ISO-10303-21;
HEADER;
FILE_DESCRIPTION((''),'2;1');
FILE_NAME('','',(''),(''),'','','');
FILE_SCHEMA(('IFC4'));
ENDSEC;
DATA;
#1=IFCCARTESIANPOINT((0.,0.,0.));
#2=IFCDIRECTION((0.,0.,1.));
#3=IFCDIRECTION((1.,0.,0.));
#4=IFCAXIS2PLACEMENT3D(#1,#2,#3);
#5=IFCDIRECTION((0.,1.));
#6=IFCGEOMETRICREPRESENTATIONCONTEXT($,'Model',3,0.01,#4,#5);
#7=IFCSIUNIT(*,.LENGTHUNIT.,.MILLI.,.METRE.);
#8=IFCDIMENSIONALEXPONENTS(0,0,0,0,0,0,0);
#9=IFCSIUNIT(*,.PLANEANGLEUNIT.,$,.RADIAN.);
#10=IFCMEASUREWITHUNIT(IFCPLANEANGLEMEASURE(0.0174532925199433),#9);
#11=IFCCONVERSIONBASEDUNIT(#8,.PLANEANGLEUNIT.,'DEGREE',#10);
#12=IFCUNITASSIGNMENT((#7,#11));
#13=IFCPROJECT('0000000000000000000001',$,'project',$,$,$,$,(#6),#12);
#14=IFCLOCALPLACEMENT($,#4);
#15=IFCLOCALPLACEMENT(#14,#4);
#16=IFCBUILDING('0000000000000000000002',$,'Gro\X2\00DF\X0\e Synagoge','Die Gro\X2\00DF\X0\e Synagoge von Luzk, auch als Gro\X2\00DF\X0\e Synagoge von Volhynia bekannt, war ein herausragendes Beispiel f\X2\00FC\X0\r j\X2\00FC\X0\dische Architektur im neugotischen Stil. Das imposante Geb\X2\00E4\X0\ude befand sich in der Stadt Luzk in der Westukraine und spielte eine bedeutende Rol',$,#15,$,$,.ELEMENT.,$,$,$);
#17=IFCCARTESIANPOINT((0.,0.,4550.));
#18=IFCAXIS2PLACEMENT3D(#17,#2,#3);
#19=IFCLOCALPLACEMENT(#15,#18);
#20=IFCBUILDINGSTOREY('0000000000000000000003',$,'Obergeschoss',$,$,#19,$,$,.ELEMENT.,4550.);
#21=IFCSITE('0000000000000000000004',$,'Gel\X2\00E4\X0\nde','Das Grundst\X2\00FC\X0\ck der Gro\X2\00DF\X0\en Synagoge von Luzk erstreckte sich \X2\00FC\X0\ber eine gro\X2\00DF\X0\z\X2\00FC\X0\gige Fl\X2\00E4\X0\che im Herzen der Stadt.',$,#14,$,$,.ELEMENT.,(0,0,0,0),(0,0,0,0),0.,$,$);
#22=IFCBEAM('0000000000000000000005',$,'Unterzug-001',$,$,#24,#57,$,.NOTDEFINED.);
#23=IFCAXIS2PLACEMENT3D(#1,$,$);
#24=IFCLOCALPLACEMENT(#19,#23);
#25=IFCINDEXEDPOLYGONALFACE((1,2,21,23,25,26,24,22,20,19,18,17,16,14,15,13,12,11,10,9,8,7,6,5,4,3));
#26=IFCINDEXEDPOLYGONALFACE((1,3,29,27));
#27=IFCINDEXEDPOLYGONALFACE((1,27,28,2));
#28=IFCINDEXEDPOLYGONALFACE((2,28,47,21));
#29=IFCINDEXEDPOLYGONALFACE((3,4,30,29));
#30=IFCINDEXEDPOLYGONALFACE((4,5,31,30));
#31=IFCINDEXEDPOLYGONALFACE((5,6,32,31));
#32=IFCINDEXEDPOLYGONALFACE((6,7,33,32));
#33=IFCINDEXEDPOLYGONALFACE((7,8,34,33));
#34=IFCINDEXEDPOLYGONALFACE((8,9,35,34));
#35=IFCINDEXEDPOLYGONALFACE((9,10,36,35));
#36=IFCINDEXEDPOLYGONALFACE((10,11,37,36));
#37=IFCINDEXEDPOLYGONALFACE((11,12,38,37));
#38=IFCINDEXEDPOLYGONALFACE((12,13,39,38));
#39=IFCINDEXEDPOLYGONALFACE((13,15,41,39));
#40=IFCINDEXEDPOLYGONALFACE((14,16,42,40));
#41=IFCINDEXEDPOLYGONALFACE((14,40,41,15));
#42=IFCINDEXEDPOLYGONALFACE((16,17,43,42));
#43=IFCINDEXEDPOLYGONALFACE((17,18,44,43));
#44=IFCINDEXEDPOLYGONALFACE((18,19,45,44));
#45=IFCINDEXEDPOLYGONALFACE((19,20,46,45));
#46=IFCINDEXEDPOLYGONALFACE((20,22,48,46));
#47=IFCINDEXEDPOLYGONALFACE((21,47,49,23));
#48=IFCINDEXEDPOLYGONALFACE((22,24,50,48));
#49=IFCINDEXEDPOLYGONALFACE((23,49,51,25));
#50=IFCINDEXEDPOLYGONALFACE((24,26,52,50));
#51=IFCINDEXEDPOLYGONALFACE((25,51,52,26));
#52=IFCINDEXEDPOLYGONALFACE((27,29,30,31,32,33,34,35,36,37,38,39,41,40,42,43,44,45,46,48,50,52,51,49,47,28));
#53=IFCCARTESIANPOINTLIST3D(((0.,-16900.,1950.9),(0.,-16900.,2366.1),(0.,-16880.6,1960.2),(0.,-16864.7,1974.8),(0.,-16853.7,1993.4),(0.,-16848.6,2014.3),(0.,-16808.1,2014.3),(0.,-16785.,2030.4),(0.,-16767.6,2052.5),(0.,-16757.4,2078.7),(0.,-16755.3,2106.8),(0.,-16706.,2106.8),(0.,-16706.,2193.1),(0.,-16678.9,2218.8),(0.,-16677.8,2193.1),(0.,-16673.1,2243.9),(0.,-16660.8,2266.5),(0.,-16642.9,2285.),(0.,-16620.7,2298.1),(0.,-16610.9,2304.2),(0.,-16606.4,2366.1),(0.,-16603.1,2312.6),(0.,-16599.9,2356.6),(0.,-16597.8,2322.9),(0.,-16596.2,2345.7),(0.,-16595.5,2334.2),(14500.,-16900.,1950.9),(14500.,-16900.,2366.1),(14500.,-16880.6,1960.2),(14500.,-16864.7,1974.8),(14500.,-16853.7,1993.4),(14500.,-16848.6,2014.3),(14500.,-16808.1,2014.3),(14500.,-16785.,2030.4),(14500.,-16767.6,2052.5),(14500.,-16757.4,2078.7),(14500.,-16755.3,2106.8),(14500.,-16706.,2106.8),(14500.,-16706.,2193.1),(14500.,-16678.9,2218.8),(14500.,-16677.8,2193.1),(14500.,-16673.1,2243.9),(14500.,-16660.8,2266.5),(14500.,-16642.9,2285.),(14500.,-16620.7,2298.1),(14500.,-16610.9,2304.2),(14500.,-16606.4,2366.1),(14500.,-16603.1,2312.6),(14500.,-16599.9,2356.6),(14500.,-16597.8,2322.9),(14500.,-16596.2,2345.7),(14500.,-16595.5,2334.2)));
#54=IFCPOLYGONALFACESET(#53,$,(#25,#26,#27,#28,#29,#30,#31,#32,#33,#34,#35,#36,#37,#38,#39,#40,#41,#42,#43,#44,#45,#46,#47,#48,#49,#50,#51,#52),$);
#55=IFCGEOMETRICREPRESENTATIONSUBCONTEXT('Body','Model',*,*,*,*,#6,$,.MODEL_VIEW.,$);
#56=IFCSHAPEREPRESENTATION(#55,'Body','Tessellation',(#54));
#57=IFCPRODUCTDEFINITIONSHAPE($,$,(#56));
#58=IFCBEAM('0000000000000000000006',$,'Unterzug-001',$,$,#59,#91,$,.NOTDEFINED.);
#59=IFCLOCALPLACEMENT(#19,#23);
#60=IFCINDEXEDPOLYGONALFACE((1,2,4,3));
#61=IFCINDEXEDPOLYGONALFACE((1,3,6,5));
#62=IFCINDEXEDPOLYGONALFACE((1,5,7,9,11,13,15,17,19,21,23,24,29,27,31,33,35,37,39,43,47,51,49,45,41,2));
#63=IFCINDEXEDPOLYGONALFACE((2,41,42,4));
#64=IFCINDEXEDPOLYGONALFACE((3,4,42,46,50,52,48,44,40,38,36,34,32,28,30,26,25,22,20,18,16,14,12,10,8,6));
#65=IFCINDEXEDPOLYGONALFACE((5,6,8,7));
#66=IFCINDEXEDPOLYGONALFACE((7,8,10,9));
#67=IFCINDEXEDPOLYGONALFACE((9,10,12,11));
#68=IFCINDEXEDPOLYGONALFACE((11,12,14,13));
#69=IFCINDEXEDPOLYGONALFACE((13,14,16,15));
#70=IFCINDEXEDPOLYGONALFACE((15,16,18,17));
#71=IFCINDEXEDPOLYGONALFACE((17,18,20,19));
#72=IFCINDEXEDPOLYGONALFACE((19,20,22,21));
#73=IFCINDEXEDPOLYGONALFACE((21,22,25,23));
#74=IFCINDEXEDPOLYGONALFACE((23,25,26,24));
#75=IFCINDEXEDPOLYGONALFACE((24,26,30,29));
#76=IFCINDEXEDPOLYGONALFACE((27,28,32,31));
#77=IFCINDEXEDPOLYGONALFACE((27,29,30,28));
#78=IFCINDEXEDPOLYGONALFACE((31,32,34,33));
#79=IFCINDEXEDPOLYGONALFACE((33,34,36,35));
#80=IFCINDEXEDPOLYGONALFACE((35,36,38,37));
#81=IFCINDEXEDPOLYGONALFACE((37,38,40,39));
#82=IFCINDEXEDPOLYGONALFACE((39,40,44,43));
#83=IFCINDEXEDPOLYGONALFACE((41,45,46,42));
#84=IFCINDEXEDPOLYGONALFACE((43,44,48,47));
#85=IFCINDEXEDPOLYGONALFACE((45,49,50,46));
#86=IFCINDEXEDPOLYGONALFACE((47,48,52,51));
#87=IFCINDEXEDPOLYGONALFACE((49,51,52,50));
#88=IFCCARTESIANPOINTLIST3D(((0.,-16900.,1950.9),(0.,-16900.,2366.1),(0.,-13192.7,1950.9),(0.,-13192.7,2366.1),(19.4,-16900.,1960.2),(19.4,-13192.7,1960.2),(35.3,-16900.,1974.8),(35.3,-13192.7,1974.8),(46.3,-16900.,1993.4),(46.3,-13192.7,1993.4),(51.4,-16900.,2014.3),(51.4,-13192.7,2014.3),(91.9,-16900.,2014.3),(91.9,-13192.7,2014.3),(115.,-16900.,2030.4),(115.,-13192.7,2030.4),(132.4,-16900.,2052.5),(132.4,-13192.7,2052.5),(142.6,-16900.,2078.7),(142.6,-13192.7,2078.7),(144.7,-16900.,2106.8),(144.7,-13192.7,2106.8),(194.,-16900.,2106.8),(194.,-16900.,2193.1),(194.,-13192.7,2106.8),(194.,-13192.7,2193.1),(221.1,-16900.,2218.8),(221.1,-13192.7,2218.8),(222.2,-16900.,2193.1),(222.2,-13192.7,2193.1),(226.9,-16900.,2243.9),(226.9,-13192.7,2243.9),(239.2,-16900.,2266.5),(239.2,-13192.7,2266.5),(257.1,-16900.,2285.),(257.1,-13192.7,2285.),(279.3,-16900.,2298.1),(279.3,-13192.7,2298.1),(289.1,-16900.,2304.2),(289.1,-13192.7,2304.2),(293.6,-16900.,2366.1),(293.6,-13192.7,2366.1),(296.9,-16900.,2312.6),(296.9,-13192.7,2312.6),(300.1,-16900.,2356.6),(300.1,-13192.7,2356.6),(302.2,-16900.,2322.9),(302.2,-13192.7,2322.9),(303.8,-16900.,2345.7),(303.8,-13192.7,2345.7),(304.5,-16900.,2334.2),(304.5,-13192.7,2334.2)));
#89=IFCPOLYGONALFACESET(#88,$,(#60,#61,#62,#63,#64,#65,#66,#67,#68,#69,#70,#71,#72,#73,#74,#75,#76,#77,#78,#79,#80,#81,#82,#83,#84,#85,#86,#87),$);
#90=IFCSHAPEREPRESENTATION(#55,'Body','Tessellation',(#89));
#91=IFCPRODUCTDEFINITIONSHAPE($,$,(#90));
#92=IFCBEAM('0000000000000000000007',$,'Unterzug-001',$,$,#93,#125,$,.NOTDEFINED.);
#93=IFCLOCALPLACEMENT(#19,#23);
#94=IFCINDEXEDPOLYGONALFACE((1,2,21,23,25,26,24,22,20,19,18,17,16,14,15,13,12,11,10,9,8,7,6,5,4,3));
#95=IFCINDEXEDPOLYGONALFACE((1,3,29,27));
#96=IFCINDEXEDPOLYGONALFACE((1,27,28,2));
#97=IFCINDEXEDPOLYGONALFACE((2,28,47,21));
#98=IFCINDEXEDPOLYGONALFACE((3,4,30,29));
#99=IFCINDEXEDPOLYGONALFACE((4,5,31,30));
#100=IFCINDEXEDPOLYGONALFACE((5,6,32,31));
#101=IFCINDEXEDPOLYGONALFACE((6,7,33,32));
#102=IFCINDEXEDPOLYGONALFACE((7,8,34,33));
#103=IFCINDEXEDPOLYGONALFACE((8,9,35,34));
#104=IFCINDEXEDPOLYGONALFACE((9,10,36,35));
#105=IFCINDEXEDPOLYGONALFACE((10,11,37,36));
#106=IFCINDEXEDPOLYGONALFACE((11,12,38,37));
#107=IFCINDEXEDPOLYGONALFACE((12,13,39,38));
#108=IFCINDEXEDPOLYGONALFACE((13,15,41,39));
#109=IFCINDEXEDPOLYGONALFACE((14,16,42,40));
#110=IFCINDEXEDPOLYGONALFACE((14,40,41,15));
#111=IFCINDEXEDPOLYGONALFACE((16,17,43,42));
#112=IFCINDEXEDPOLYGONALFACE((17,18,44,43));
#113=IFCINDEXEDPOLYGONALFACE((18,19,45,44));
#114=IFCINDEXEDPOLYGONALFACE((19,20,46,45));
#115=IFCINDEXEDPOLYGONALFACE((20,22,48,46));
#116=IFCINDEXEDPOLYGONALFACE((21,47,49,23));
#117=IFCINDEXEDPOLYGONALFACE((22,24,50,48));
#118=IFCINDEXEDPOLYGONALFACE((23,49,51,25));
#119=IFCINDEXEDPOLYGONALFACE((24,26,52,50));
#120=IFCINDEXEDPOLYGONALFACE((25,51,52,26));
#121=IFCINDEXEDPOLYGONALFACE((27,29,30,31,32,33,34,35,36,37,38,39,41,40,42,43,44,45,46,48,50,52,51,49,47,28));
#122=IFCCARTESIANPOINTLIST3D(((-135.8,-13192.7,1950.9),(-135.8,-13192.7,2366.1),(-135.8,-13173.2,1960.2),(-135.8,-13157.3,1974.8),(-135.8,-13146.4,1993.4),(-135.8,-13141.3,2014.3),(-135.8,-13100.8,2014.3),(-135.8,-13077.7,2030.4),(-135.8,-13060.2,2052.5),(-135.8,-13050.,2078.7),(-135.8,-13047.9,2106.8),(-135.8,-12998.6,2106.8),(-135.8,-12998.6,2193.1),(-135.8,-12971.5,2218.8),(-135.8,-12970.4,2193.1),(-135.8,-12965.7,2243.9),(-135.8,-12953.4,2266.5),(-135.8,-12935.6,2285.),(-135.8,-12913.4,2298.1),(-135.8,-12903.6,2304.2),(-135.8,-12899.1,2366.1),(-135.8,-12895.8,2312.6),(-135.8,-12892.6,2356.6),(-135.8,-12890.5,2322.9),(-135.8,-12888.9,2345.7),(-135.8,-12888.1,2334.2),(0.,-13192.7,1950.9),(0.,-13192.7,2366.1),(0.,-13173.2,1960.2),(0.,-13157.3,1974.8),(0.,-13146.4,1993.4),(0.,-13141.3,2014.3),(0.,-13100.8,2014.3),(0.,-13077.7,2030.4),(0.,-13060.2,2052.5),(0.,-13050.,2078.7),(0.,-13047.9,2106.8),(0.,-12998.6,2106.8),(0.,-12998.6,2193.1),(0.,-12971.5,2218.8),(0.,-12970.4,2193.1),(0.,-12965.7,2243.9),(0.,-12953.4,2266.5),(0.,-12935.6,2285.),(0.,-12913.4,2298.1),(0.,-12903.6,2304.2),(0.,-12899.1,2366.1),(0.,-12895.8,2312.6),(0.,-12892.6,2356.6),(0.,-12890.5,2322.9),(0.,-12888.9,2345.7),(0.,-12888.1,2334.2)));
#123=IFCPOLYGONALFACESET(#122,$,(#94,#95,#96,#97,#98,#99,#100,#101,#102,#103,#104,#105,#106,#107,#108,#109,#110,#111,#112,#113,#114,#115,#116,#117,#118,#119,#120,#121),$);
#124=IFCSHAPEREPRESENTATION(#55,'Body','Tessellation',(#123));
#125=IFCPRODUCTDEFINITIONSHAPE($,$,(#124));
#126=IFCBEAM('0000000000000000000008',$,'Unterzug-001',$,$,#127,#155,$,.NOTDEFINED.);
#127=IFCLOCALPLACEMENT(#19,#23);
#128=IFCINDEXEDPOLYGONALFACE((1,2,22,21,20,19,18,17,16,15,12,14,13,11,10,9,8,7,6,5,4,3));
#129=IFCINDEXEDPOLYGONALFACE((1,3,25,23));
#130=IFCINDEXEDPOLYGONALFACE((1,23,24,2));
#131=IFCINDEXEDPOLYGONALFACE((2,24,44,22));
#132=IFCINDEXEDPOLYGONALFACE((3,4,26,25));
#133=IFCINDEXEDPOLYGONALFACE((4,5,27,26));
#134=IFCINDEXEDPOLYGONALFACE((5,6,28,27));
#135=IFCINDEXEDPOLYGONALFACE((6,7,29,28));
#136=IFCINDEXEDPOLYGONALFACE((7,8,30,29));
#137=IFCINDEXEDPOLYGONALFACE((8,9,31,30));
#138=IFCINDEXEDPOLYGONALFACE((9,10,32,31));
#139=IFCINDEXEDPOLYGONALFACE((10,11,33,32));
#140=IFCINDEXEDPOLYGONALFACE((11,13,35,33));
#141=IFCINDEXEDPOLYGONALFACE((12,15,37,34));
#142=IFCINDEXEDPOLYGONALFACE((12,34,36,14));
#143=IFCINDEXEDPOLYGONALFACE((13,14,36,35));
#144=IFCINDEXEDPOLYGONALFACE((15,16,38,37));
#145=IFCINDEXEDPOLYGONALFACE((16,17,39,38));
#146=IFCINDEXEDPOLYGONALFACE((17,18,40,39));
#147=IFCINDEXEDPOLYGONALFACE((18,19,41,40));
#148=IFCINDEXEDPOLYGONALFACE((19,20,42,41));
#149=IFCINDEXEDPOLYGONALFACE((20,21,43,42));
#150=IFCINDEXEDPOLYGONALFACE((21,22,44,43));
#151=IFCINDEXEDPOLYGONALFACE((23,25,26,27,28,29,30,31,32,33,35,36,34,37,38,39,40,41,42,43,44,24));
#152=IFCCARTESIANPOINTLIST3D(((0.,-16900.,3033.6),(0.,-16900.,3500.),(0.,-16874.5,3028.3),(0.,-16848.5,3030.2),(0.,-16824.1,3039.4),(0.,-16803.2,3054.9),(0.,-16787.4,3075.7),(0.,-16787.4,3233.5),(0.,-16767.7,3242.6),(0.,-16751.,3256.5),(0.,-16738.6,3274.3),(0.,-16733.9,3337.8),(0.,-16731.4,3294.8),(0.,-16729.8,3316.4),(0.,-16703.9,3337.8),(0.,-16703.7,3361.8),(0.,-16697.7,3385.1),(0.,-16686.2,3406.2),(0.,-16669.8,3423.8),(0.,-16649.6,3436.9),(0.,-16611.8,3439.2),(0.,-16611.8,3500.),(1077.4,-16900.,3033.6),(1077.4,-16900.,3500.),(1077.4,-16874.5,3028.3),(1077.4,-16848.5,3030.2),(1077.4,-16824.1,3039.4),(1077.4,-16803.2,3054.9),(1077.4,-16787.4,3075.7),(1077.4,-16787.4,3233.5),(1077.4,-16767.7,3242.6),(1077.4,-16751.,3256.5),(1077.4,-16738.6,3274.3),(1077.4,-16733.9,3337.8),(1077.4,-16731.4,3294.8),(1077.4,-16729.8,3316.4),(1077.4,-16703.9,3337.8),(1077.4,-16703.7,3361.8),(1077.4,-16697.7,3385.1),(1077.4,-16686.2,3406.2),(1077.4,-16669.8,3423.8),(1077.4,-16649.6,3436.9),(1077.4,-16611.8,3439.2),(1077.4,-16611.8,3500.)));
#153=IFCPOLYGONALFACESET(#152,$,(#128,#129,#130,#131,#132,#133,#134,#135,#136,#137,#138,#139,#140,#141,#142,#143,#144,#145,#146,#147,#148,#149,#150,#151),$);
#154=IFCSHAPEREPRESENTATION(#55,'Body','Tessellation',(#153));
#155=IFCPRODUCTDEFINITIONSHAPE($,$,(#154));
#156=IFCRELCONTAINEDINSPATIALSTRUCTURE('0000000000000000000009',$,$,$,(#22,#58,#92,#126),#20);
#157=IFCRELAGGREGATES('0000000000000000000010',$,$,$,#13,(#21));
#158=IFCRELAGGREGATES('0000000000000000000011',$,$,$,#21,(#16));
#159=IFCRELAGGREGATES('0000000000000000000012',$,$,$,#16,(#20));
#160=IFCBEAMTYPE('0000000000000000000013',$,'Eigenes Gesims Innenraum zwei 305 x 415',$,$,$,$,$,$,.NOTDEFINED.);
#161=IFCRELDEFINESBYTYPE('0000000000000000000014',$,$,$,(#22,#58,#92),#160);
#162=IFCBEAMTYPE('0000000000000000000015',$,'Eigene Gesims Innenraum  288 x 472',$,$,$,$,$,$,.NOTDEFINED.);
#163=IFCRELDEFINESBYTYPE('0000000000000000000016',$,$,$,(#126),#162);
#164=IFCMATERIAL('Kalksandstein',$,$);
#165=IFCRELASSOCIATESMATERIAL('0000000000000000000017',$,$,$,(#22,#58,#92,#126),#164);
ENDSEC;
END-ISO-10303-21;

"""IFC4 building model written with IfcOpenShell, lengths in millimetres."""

from ifc_helpers import new_model, entity, si_unit, converted_unit, direction, frame, origin_with_axes, place, context, subcontext, project, spatial, line, arc, indexed_curve, outline, extrude, material, material_profile, profile_set, type_object, element, save


model = new_model("IFC4")

# Units and contexts
model_context = context("Model", 3, precision=0.01, world=origin_with_axes(), true_north=direction((0.0, 1.0)))
body_context = subcontext(model_context, "Body", "Model", "MODEL_VIEW")
ifc_project = project(units=[si_unit("LENGTHUNIT", "METRE", prefix="MILLI"), converted_unit("PLANEANGLEUNIT", "DEGREE", entity("IfcPlaneAngleMeasure", 0.0174532925199433), si_unit("PLANEANGLEUNIT", "RADIAN"), dimensions=[0, 0, 0, 0, 0, 0, 0])], contexts=[model_context])

# Site, building, storey
site_placement = place(None, origin_with_axes())
site = spatial("IfcSite", under=ifc_project, at=site_placement, Name="Gelände", Description="Das Grundstück der Großen Synagoge von Luzk erstreckte sich über eine großzügige Fläche im Herzen der Stadt.", CompositionType="ELEMENT", RefLatitude=(0, 0, 0, 0), RefLongitude=(0, 0, 0, 0), RefElevation=0.0)
building_placement = place(site_placement, origin_with_axes())
building = spatial("IfcBuilding", under=site, at=building_placement, Name="Große Synagoge", Description="Die Große Synagoge von Luzk, auch als Große Synagoge von Volhynia bekannt, war ein herausragendes Beispiel für jüdische Architektur im neugotischen Stil. Das imposante Gebäude befand sich in der Stadt Luzk in der Westukraine und spielte eine bedeutende Rol", CompositionType="ELEMENT")
storey_placement = place(building_placement, frame((0.0, 0.0, 4550.0), z_axis=(0.0, 0.0, 1.0), x_axis=(1.0, 0.0, 0.0)))
storey = spatial("IfcBuildingStorey", under=building, at=storey_placement, Name="Obergeschoss", CompositionType="ELEMENT", Elevation=4550.0)

# Beams
ifc_material_1 = material(Name="Kalksandstein")
ifc_material_profile_1 = material_profile(ifc_material_1, outline(indexed_curve([(194.0, -173.0), (222.2, -173.0), (232.3, -110.5), (279.3, -68.0), (303.7, -37.6), (293.6, 0.0), (0.0, 0.0), (0.0, -415.2), (35.3, -391.3), (51.4, -351.7), (91.9, -351.7), (132.4, -313.6), (144.7, -259.3), (194.0, -259.3)], segments=[line(1, 2), arc(2, 3, 4), arc(4, 5, 6), line(6, 7, 8), arc(8, 9, 10), line(10, 11), arc(11, 12, 13), line(13, 14, 1)])), Name="Kalksandstein")
ifc_profile_set_1 = profile_set([ifc_material_profile_1], Name="Eigenes Gesims Innenraum zwei")
beam_type_1 = type_object("IfcBeamType", Name="Eigenes Gesims Innenraum zwei 305 x 415", PredefinedType="NOTDEFINED")
beam_1_placement = place(storey_placement, frame((0.0, -16900.0, 2366.1), z_axis=(0.0, 0.0, 1.0), x_axis=(0.0, -1.0, 0.0)))
element("IfcBeam", 1, at=beam_1_placement, inside=storey, type_object=beam_type_1, material=ifc_profile_set_1, Name="Unterzug-001", PredefinedType="NOTDEFINED", context=body_context, shape_type="SweptSolid", body=[
    extrude(outline(indexed_curve([(194.0, -173.0), (222.2, -173.0), (232.3, -110.5), (279.3, -68.0), (303.7, -37.6), (293.6, 0.0), (0.0, 0.0), (0.0, -415.2), (35.3, -391.3), (51.4, -351.7), (91.9, -351.7), (132.4, -313.6), (144.7, -259.3), (194.0, -259.3)], segments=[line(1, 2), arc(2, 3, 4), arc(4, 5, 6), line(6, 7, 8), arc(8, 9, 10), line(10, 11), arc(11, 12, 13), line(13, 14, 1)])), frame((0.0, 14500.0, 0.0), z_axis=(0.0, 1.0, 0.0), x_axis=(-1.0, 0.0, 0.0)), (0.0, 0.0, -1.0), 14500.0),
])
beam_2_placement = place(storey_placement, frame((0.0, -16900.0, 2366.1), z_axis=(0.0, 0.0, 1.0), x_axis=(1.0, 0.0, 0.0)))
element("IfcBeam", 2, at=beam_2_placement, inside=storey, type_object=beam_type_1, material=ifc_profile_set_1, Name="Unterzug-001", PredefinedType="NOTDEFINED", context=body_context, shape_type="SweptSolid", body=[
    extrude(outline(indexed_curve([(194.0, -173.0), (222.2, -173.0), (232.3, -110.5), (279.3, -68.0), (303.7, -37.6), (293.6, 0.0), (0.0, 0.0), (0.0, -415.2), (35.3, -391.3), (51.4, -351.7), (91.9, -351.7), (132.4, -313.6), (144.7, -259.3), (194.0, -259.3)], segments=[line(1, 2), arc(2, 3, 4), arc(4, 5, 6), line(6, 7, 8), arc(8, 9, 10), line(10, 11), arc(11, 12, 13), line(13, 14, 1)])), frame((0.0, 3707.3, 0.0), z_axis=(0.0, -1.0, 0.0), x_axis=(1.0, 0.0, 0.0)), (0.0, 0.0, 1.0), 3707.3),
])
beam_3_placement = place(storey_placement, frame((0.0, -13192.7, 2366.1), z_axis=(0.0, 0.0, 1.0), x_axis=(0.0, 1.0, 0.0)))
element("IfcBeam", 3, at=beam_3_placement, inside=storey, type_object=beam_type_1, material=ifc_profile_set_1, Name="Unterzug-001", PredefinedType="NOTDEFINED", context=body_context, shape_type="SweptSolid", body=[
    extrude(outline(indexed_curve([(194.0, -173.0), (222.2, -173.0), (232.3, -110.5), (279.3, -68.0), (303.7, -37.6), (293.6, 0.0), (0.0, 0.0), (0.0, -415.2), (35.3, -391.3), (51.4, -351.7), (91.9, -351.7), (132.4, -313.6), (144.7, -259.3), (194.0, -259.3)], segments=[line(1, 2), arc(2, 3, 4), arc(4, 5, 6), line(6, 7, 8), arc(8, 9, 10), line(10, 11), arc(11, 12, 13), line(13, 14, 1)])), frame((0.0, 135.8, 0.0), z_axis=(0.0, -1.0, 0.0), x_axis=(1.0, 0.0, 0.0)), (0.0, 0.0, 1.0), 135.8),
])
ifc_material_profile_2 = material_profile(ifc_material_1, outline(indexed_curve([(0.0, 0.0), (0.0, -466.4), (64.0, -466.1), (112.6, -424.3), (112.6, -266.5), (161.4, -225.7), (166.1, -162.2), (196.1, -162.2), (207.4, -104.0), (250.4, -63.1), (288.2, -60.8), (288.2, 0.0)], segments=[line(1, 2), arc(2, 3, 4), line(4, 5), arc(5, 6, 7), line(7, 8), arc(8, 9, 10), line(10, 11, 12, 1)])), Name="Kalksandstein")
ifc_profile_set_2 = profile_set([ifc_material_profile_2], Name="Eigene Gesims Innenraum ")
beam_type_2 = type_object("IfcBeamType", Name="Eigene Gesims Innenraum  288 x 472", PredefinedType="NOTDEFINED")
beam_4_placement = place(storey_placement, frame((0.0, -16900.0, 3500.0), z_axis=(0.0, 0.0, 1.0), x_axis=(0.0, -1.0, 0.0)))
element("IfcBeam", 4, at=beam_4_placement, inside=storey, type_object=beam_type_2, material=ifc_profile_set_2, Name="Unterzug-001", PredefinedType="NOTDEFINED", context=body_context, shape_type="SweptSolid", body=[
    extrude(outline(indexed_curve([(0.0, 0.0), (0.0, -466.4), (64.0, -466.1), (112.6, -424.3), (112.6, -266.5), (161.4, -225.7), (166.1, -162.2), (196.1, -162.2), (207.4, -104.0), (250.4, -63.1), (288.2, -60.8), (288.2, 0.0)], segments=[line(1, 2), arc(2, 3, 4), line(4, 5), arc(5, 6, 7), line(7, 8), arc(8, 9, 10), line(10, 11, 12, 1)])), frame((0.0, 1077.4, 0.0), z_axis=(0.0, 1.0, 0.0), x_axis=(-1.0, 0.0, 0.0)), (0.0, 0.0, -1.0), 1077.4),
])

save(model, "model.ifc")
